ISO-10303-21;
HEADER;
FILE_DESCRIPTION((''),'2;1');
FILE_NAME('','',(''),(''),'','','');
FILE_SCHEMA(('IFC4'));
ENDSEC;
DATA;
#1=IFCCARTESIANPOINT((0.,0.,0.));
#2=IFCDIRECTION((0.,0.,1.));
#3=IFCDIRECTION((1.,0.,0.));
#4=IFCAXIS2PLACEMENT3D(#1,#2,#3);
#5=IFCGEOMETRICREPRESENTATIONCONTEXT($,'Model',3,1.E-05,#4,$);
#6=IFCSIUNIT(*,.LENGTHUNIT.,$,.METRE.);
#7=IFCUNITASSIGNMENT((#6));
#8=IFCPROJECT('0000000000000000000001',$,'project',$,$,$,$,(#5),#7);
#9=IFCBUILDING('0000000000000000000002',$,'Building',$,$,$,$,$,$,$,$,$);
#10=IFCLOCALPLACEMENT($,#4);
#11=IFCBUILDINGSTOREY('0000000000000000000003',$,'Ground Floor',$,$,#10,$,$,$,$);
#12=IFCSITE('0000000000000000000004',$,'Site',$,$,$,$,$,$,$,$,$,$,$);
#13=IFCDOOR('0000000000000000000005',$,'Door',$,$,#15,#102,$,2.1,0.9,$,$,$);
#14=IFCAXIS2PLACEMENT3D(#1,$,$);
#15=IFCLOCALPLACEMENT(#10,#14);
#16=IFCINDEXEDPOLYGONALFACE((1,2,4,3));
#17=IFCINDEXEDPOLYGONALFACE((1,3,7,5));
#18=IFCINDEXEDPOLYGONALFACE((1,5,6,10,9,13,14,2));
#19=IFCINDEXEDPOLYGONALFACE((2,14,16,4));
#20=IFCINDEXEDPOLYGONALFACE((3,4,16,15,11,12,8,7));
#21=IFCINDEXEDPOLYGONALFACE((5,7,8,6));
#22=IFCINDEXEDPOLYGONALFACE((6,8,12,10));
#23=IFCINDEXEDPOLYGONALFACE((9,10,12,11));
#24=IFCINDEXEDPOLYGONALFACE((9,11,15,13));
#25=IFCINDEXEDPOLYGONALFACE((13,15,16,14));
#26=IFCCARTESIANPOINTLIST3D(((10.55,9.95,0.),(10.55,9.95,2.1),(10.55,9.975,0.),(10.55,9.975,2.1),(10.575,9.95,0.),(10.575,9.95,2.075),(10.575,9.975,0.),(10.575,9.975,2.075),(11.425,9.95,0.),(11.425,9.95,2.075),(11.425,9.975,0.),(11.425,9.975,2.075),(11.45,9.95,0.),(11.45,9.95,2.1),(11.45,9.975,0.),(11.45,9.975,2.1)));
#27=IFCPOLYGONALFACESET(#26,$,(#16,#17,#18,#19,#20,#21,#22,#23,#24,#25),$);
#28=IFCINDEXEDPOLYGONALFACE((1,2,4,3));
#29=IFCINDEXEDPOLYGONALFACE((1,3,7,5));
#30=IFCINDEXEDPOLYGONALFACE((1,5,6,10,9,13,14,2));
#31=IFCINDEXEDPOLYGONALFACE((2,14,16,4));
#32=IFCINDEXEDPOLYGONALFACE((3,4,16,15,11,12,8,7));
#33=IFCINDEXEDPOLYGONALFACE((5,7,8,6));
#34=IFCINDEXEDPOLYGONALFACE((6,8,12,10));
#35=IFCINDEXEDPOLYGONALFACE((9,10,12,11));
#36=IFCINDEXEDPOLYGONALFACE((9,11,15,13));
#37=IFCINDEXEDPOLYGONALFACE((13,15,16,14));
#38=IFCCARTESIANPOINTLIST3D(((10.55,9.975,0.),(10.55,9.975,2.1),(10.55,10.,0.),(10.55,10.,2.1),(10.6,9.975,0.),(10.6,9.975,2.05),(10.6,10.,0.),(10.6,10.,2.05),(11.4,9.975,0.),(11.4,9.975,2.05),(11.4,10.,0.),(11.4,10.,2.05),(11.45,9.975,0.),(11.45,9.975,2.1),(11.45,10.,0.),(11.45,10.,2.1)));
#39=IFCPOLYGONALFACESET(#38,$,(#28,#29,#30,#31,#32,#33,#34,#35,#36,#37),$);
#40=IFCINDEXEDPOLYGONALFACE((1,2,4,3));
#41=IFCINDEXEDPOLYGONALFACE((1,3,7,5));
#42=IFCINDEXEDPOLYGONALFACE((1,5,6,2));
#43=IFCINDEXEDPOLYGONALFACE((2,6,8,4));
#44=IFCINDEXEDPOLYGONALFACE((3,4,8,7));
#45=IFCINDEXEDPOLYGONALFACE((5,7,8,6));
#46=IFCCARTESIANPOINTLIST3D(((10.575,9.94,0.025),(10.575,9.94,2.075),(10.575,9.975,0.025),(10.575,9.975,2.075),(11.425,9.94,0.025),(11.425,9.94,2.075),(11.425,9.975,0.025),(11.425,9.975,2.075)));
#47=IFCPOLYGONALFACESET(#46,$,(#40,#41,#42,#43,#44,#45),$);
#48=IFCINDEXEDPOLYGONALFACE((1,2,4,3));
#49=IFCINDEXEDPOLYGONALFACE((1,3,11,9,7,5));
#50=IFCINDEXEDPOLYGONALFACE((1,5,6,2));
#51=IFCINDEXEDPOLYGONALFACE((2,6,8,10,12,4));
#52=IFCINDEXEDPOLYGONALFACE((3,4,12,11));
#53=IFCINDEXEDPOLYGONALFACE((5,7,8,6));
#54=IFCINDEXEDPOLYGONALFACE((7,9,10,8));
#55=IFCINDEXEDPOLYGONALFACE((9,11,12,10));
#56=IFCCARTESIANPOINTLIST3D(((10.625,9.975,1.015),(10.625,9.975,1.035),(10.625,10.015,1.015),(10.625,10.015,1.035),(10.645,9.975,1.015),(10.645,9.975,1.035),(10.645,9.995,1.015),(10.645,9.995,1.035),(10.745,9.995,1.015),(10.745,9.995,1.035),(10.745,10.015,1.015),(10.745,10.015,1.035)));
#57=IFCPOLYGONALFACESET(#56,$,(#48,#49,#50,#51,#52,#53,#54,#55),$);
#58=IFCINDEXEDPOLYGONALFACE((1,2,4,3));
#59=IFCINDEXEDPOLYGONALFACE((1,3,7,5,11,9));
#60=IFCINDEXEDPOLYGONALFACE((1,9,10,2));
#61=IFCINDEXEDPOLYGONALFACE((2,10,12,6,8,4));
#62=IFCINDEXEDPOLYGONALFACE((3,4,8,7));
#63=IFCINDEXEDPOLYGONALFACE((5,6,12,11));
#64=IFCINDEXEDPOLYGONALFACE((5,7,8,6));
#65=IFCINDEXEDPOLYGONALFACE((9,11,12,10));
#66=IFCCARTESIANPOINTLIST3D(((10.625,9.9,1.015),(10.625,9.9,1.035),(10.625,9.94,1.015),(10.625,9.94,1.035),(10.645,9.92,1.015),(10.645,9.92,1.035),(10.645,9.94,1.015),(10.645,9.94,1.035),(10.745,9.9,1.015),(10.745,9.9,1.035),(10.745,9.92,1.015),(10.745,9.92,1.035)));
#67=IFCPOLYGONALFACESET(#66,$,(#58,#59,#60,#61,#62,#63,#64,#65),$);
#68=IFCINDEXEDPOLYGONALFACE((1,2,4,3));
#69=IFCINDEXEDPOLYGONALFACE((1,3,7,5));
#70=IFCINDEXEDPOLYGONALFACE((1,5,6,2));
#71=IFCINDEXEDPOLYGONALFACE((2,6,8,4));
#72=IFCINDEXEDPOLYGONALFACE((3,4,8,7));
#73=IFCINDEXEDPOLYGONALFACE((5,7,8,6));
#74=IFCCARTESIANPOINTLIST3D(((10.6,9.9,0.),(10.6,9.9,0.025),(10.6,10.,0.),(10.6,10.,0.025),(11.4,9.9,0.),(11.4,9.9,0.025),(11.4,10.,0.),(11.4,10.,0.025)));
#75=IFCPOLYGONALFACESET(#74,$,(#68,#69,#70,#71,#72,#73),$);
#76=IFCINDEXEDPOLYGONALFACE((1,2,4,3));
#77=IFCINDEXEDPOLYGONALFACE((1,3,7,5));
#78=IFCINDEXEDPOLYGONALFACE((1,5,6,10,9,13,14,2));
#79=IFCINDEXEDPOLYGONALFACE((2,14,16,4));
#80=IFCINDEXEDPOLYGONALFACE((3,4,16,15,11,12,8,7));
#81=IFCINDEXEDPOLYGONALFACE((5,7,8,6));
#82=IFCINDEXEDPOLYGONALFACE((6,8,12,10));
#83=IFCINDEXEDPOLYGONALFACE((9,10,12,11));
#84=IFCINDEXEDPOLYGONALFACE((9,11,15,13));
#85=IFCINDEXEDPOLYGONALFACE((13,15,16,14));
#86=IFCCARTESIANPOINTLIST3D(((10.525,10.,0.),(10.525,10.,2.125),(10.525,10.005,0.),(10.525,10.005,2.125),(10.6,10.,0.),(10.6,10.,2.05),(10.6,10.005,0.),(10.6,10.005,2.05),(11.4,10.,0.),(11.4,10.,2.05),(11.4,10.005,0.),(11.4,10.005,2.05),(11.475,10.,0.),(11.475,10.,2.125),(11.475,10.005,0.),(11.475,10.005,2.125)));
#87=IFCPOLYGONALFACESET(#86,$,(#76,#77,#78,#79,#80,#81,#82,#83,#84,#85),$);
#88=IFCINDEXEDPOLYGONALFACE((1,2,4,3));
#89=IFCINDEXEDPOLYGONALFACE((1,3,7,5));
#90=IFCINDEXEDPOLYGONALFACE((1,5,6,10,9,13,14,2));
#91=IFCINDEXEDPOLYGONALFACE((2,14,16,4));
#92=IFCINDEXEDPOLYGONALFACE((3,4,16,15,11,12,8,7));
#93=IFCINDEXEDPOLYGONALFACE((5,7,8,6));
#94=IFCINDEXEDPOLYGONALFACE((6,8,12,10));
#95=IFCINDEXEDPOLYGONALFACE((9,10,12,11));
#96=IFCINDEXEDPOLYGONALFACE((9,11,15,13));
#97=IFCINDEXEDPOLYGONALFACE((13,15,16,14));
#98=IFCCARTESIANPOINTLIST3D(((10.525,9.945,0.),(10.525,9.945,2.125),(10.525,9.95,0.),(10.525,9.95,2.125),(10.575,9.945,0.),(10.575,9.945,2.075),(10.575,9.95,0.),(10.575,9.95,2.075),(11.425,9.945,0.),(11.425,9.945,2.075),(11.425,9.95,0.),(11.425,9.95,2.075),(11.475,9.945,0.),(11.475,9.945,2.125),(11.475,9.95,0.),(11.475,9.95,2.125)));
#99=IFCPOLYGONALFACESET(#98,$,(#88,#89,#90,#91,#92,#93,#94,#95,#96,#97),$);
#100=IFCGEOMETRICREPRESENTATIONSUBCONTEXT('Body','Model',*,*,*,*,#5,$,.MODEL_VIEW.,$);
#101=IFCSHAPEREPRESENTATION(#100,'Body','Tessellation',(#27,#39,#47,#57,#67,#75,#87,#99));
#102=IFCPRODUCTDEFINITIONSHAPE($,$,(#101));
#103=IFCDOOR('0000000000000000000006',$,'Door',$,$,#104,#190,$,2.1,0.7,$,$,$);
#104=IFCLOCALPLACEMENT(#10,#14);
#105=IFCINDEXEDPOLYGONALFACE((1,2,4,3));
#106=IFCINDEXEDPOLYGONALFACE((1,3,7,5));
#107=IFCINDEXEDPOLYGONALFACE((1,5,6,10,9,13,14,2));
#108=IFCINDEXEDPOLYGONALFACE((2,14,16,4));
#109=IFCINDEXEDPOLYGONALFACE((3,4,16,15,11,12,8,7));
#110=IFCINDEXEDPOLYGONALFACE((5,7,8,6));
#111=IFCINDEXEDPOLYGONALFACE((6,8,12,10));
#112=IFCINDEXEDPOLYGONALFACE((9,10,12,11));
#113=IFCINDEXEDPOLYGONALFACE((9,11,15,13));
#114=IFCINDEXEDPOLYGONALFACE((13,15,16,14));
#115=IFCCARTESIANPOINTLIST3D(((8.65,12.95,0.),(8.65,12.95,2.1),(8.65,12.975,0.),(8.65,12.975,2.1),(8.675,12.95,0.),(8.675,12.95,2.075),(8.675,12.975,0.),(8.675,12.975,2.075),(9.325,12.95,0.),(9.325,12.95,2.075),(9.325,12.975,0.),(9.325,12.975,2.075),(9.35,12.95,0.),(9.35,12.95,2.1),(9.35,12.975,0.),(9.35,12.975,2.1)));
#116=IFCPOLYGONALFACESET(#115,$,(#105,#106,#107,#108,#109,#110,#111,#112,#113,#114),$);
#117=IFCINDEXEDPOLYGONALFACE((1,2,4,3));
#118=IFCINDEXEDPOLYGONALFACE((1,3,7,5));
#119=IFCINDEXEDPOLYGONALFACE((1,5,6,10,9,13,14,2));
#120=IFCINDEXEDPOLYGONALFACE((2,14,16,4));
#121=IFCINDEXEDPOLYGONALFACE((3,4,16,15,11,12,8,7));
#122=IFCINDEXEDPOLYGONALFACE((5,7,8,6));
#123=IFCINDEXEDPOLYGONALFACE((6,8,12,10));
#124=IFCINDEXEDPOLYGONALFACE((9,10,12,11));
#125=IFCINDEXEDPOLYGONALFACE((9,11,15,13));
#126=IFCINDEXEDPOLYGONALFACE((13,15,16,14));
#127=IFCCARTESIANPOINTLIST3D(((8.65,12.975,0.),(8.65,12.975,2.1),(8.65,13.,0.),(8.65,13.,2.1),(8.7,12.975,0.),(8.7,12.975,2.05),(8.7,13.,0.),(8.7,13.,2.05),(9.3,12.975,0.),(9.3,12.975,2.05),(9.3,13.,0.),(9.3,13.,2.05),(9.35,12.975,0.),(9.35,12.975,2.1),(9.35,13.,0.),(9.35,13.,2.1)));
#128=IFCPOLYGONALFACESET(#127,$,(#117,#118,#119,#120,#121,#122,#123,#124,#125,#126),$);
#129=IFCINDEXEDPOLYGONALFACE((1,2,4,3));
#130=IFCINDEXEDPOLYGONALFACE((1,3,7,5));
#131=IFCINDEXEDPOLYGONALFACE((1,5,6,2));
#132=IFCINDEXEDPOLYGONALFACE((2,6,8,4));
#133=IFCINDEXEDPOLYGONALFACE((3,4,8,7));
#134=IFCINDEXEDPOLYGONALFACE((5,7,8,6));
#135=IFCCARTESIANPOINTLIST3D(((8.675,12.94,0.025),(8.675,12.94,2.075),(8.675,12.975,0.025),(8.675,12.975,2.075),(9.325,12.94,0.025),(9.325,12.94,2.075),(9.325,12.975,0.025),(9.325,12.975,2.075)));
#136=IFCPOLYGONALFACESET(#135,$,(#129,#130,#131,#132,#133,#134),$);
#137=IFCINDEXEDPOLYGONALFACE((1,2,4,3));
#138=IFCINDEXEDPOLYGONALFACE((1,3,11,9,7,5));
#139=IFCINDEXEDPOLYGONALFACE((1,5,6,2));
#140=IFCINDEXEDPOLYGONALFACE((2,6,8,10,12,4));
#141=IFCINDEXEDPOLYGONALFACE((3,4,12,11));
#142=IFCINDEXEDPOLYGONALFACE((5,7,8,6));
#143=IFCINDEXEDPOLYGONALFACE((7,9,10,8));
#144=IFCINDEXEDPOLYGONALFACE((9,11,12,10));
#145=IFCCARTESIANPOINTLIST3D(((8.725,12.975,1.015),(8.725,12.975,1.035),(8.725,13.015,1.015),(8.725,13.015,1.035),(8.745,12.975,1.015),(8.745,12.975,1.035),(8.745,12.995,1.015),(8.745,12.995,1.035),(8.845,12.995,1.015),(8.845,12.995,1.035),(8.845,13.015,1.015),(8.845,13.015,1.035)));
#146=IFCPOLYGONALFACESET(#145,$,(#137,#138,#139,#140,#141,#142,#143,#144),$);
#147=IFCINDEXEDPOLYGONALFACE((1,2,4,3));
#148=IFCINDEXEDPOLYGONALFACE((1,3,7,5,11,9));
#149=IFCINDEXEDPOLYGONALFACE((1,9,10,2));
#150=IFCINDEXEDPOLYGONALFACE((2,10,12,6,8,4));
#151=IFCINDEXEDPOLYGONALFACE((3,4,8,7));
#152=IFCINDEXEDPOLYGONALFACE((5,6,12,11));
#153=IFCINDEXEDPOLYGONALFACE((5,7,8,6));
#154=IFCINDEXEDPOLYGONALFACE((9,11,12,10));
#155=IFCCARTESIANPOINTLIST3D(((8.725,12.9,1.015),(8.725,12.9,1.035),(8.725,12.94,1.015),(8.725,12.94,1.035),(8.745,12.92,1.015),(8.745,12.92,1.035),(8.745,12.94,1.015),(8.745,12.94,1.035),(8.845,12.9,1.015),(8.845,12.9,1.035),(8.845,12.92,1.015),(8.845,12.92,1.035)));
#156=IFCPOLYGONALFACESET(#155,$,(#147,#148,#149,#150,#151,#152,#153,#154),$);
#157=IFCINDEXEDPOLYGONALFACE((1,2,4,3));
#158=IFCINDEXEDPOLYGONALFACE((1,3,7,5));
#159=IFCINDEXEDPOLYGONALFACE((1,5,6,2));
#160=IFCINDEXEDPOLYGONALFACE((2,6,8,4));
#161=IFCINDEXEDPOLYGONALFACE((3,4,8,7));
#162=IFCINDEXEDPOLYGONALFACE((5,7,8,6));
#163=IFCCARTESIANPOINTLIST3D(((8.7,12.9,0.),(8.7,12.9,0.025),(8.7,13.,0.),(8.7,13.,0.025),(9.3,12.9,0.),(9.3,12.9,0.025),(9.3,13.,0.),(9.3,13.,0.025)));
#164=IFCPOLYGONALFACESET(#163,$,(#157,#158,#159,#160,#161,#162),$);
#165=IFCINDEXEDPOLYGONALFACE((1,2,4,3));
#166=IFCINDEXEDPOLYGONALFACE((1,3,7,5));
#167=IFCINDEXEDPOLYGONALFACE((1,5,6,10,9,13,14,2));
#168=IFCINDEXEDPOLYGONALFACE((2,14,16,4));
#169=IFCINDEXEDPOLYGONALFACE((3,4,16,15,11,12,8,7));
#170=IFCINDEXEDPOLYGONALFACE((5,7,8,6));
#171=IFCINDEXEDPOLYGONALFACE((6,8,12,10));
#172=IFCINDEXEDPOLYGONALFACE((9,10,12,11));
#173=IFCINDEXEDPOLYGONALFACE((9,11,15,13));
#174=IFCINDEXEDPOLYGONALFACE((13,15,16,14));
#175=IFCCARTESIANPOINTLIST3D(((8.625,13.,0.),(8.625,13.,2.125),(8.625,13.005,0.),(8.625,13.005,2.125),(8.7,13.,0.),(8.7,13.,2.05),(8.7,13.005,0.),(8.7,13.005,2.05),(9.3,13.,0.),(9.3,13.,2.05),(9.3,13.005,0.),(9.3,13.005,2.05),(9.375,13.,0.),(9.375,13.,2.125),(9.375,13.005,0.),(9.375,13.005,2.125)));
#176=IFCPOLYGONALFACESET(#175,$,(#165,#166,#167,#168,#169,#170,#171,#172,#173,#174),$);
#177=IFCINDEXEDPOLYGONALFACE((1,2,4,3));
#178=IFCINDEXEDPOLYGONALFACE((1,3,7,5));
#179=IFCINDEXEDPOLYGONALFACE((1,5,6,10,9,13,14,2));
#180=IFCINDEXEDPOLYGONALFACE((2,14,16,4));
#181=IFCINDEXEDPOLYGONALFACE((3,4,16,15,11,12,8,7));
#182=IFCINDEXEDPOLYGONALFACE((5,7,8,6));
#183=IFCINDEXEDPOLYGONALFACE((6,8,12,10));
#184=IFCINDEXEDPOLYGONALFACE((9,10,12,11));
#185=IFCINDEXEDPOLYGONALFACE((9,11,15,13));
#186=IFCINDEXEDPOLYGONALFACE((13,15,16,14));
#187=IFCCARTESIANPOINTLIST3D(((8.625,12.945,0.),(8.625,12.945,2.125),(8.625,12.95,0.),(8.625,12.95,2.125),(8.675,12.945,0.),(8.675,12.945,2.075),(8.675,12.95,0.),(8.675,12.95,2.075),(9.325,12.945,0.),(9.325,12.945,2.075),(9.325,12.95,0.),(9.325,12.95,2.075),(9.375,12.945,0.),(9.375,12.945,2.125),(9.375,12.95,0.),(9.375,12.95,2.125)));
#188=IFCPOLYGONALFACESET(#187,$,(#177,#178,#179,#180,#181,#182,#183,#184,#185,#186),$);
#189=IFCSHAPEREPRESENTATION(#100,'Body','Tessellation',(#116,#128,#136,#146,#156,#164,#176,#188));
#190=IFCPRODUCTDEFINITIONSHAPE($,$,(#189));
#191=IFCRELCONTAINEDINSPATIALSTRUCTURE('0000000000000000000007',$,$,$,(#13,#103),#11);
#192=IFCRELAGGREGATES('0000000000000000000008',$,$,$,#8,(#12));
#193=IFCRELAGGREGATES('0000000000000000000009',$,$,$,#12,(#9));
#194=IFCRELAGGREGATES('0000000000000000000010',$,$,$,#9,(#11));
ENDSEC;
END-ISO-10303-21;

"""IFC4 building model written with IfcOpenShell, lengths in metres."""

from ifc_helpers import new_model, si_unit, frame, origin_with_axes, place, context, subcontext, project, spatial, line, indexed_curve, outline, extrude, element, save


model = new_model("IFC4")

# Units and contexts
model_context = context("Model", 3, precision=1e-05, world=origin_with_axes())
body_context = subcontext(model_context, "Body", "Model", "MODEL_VIEW")
ifc_project = project(units=[si_unit("LENGTHUNIT", "METRE")], contexts=[model_context])

# Site, building, storey
site = spatial("IfcSite", under=ifc_project, Name="Site")
building = spatial("IfcBuilding", under=site, Name="Building")
storey_placement = place(None, origin_with_axes())
storey = spatial("IfcBuildingStorey", under=building, at=storey_placement, Name="Ground Floor")

# Doors
door_1_placement = place(storey_placement, frame((11.45, 10.0, 0.0), z_axis=(0.0, 0.0, 1.0), x_axis=(-1.0, 0.0, 0.0)))
element("IfcDoor", 1, at=door_1_placement, inside=storey, Name="Door", OverallHeight=2.1, OverallWidth=0.9, context=body_context, shape_type="SweptSolid", body=[
    extrude(outline(indexed_curve([(0.0, 0.0), (0.0, 2.1), (0.9, 2.1), (0.9, 0.0), (0.875, 0.0), (0.875, 2.075), (0.025, 2.075), (0.025, 0.0)], segments=[line(1, 2, 3, 4, 5, 6, 7, 8, 1)])), frame((0.0, 0.025, 0.0), z_axis=(0.0, -1.0, 0.0), x_axis=(1.0, 0.0, 0.0)), (0.0, 0.0, -1.0), 0.025),
    extrude(outline(indexed_curve([(0.0, 0.0), (0.0, 2.1), (0.9, 2.1), (0.9, 0.0), (0.85, 0.0), (0.85, 2.05), (0.05, 2.05), (0.05, 0.0)], segments=[line(1, 2, 3, 4, 5, 6, 7, 8, 1)])), frame((0.0, 0.0, 0.0), z_axis=(0.0, -1.0, 0.0), x_axis=(1.0, 0.0, 0.0)), (0.0, 0.0, -1.0), 0.025),
    extrude(outline(indexed_curve([(0.0, 0.0), (0.85, 0.0), (0.85, 0.035), (0.0, 0.035)], segments=[line(1, 2, 3, 4, 1)])), frame((0.025, 0.025, 0.025), z_axis=(0.0, 0.0, 1.0), x_axis=(1.0, 0.0, 0.0)), (0.0, 0.0, 1.0), 2.05),
    extrude(outline(indexed_curve([(0.0, 0.0), (0.0, -0.04), (-0.12, -0.04), (-0.12, -0.02), (-0.02, -0.02), (-0.02, 0.0)], segments=[line(1, 2, 3, 4, 5, 6, 1)])), frame((0.825, 0.025, 1.015), z_axis=(0.0, 0.0, 1.0), x_axis=(1.0, 0.0, 0.0)), (0.0, 0.0, 1.0), 0.02),
    extrude(outline(indexed_curve([(0.0, 0.0), (0.0, 0.04), (-0.12, 0.04), (-0.12, 0.02), (-0.02, 0.02), (-0.02, 0.0)], segments=[line(1, 2, 3, 4, 5, 6, 1)])), frame((0.825, 0.06, 1.015), z_axis=(0.0, 0.0, 1.0), x_axis=(1.0, 0.0, 0.0)), (0.0, 0.0, 1.0), 0.02),
    extrude(outline(indexed_curve([(0.0, 0.0), (0.8, 0.0), (0.8, 0.1), (0.0, 0.1)], segments=[line(1, 2, 3, 4, 1)])), frame((0.05, 0.0, 0.0), z_axis=(0.0, 0.0, 1.0), x_axis=(1.0, 0.0, 0.0)), (0.0, 0.0, 1.0), 0.025),
    extrude(outline(indexed_curve([(0.0, 0.0), (0.0, 2.125), (0.95, 2.125), (0.95, 0.0), (0.875, 0.0), (0.875, 2.05), (0.075, 2.05), (0.075, 0.0)], segments=[line(1, 2, 3, 4, 5, 6, 7, 8, 1)])), frame((-0.025, -0.005, 0.0), z_axis=(0.0, -1.0, 0.0), x_axis=(1.0, 0.0, 0.0)), (0.0, 0.0, -1.0), 0.005),
    extrude(outline(indexed_curve([(0.0, 0.0), (0.0, 2.125), (0.95, 2.125), (0.95, 0.0), (0.9, 0.0), (0.9, 2.075), (0.05, 2.075), (0.05, 0.0)], segments=[line(1, 2, 3, 4, 5, 6, 7, 8, 1)])), frame((-0.025, 0.05, 0.0), z_axis=(0.0, -1.0, 0.0), x_axis=(1.0, 0.0, 0.0)), (0.0, 0.0, -1.0), 0.005),
])
door_2_placement = place(storey_placement, frame((9.35, 13.0, 0.0), z_axis=(0.0, 0.0, 1.0), x_axis=(-1.0, 0.0, 0.0)))
element("IfcDoor", 2, at=door_2_placement, inside=storey, Name="Door", OverallHeight=2.1, OverallWidth=0.7, context=body_context, shape_type="SweptSolid", body=[
    extrude(outline(indexed_curve([(0.0, 0.0), (0.0, 2.1), (0.7, 2.1), (0.7, 0.0), (0.675, 0.0), (0.675, 2.075), (0.025, 2.075), (0.025, 0.0)], segments=[line(1, 2, 3, 4, 5, 6, 7, 8, 1)])), frame((0.0, 0.025, 0.0), z_axis=(0.0, -1.0, 0.0), x_axis=(1.0, 0.0, 0.0)), (0.0, 0.0, -1.0), 0.025),
    extrude(outline(indexed_curve([(0.0, 0.0), (0.0, 2.1), (0.7, 2.1), (0.7, 0.0), (0.65, 0.0), (0.65, 2.05), (0.05, 2.05), (0.05, 0.0)], segments=[line(1, 2, 3, 4, 5, 6, 7, 8, 1)])), frame((0.0, 0.0, 0.0), z_axis=(0.0, -1.0, 0.0), x_axis=(1.0, 0.0, 0.0)), (0.0, 0.0, -1.0), 0.025),
    extrude(outline(indexed_curve([(0.0, 0.0), (0.65, 0.0), (0.65, 0.035), (0.0, 0.035)], segments=[line(1, 2, 3, 4, 1)])), frame((0.025, 0.025, 0.025), z_axis=(0.0, 0.0, 1.0), x_axis=(1.0, 0.0, 0.0)), (0.0, 0.0, 1.0), 2.05),
    extrude(outline(indexed_curve([(0.0, 0.0), (0.0, -0.04), (-0.12, -0.04), (-0.12, -0.02), (-0.02, -0.02), (-0.02, 0.0)], segments=[line(1, 2, 3, 4, 5, 6, 1)])), frame((0.625, 0.025, 1.015), z_axis=(0.0, 0.0, 1.0), x_axis=(1.0, 0.0, 0.0)), (0.0, 0.0, 1.0), 0.02),
    extrude(outline(indexed_curve([(0.0, 0.0), (0.0, 0.04), (-0.12, 0.04), (-0.12, 0.02), (-0.02, 0.02), (-0.02, 0.0)], segments=[line(1, 2, 3, 4, 5, 6, 1)])), frame((0.625, 0.06, 1.015), z_axis=(0.0, 0.0, 1.0), x_axis=(1.0, 0.0, 0.0)), (0.0, 0.0, 1.0), 0.02),
    extrude(outline(indexed_curve([(0.0, 0.0), (0.6, 0.0), (0.6, 0.1), (0.0, 0.1)], segments=[line(1, 2, 3, 4, 1)])), frame((0.05, 0.0, 0.0), z_axis=(0.0, 0.0, 1.0), x_axis=(1.0, 0.0, 0.0)), (0.0, 0.0, 1.0), 0.025),
    extrude(outline(indexed_curve([(0.0, 0.0), (0.0, 2.125), (0.75, 2.125), (0.75, 0.0), (0.675, 0.0), (0.675, 2.05), (0.075, 2.05), (0.075, 0.0)], segments=[line(1, 2, 3, 4, 5, 6, 7, 8, 1)])), frame((-0.025, -0.005, 0.0), z_axis=(0.0, -1.0, 0.0), x_axis=(1.0, 0.0, 0.0)), (0.0, 0.0, -1.0), 0.005),
    extrude(outline(indexed_curve([(0.0, 0.0), (0.0, 2.125), (0.75, 2.125), (0.75, 0.0), (0.7, 0.0), (0.7, 2.075), (0.05, 2.075), (0.05, 0.0)], segments=[line(1, 2, 3, 4, 5, 6, 7, 8, 1)])), frame((-0.025, 0.05, 0.0), z_axis=(0.0, -1.0, 0.0), x_axis=(1.0, 0.0, 0.0)), (0.0, 0.0, -1.0), 0.005),
])

save(model, "model.ifc")
